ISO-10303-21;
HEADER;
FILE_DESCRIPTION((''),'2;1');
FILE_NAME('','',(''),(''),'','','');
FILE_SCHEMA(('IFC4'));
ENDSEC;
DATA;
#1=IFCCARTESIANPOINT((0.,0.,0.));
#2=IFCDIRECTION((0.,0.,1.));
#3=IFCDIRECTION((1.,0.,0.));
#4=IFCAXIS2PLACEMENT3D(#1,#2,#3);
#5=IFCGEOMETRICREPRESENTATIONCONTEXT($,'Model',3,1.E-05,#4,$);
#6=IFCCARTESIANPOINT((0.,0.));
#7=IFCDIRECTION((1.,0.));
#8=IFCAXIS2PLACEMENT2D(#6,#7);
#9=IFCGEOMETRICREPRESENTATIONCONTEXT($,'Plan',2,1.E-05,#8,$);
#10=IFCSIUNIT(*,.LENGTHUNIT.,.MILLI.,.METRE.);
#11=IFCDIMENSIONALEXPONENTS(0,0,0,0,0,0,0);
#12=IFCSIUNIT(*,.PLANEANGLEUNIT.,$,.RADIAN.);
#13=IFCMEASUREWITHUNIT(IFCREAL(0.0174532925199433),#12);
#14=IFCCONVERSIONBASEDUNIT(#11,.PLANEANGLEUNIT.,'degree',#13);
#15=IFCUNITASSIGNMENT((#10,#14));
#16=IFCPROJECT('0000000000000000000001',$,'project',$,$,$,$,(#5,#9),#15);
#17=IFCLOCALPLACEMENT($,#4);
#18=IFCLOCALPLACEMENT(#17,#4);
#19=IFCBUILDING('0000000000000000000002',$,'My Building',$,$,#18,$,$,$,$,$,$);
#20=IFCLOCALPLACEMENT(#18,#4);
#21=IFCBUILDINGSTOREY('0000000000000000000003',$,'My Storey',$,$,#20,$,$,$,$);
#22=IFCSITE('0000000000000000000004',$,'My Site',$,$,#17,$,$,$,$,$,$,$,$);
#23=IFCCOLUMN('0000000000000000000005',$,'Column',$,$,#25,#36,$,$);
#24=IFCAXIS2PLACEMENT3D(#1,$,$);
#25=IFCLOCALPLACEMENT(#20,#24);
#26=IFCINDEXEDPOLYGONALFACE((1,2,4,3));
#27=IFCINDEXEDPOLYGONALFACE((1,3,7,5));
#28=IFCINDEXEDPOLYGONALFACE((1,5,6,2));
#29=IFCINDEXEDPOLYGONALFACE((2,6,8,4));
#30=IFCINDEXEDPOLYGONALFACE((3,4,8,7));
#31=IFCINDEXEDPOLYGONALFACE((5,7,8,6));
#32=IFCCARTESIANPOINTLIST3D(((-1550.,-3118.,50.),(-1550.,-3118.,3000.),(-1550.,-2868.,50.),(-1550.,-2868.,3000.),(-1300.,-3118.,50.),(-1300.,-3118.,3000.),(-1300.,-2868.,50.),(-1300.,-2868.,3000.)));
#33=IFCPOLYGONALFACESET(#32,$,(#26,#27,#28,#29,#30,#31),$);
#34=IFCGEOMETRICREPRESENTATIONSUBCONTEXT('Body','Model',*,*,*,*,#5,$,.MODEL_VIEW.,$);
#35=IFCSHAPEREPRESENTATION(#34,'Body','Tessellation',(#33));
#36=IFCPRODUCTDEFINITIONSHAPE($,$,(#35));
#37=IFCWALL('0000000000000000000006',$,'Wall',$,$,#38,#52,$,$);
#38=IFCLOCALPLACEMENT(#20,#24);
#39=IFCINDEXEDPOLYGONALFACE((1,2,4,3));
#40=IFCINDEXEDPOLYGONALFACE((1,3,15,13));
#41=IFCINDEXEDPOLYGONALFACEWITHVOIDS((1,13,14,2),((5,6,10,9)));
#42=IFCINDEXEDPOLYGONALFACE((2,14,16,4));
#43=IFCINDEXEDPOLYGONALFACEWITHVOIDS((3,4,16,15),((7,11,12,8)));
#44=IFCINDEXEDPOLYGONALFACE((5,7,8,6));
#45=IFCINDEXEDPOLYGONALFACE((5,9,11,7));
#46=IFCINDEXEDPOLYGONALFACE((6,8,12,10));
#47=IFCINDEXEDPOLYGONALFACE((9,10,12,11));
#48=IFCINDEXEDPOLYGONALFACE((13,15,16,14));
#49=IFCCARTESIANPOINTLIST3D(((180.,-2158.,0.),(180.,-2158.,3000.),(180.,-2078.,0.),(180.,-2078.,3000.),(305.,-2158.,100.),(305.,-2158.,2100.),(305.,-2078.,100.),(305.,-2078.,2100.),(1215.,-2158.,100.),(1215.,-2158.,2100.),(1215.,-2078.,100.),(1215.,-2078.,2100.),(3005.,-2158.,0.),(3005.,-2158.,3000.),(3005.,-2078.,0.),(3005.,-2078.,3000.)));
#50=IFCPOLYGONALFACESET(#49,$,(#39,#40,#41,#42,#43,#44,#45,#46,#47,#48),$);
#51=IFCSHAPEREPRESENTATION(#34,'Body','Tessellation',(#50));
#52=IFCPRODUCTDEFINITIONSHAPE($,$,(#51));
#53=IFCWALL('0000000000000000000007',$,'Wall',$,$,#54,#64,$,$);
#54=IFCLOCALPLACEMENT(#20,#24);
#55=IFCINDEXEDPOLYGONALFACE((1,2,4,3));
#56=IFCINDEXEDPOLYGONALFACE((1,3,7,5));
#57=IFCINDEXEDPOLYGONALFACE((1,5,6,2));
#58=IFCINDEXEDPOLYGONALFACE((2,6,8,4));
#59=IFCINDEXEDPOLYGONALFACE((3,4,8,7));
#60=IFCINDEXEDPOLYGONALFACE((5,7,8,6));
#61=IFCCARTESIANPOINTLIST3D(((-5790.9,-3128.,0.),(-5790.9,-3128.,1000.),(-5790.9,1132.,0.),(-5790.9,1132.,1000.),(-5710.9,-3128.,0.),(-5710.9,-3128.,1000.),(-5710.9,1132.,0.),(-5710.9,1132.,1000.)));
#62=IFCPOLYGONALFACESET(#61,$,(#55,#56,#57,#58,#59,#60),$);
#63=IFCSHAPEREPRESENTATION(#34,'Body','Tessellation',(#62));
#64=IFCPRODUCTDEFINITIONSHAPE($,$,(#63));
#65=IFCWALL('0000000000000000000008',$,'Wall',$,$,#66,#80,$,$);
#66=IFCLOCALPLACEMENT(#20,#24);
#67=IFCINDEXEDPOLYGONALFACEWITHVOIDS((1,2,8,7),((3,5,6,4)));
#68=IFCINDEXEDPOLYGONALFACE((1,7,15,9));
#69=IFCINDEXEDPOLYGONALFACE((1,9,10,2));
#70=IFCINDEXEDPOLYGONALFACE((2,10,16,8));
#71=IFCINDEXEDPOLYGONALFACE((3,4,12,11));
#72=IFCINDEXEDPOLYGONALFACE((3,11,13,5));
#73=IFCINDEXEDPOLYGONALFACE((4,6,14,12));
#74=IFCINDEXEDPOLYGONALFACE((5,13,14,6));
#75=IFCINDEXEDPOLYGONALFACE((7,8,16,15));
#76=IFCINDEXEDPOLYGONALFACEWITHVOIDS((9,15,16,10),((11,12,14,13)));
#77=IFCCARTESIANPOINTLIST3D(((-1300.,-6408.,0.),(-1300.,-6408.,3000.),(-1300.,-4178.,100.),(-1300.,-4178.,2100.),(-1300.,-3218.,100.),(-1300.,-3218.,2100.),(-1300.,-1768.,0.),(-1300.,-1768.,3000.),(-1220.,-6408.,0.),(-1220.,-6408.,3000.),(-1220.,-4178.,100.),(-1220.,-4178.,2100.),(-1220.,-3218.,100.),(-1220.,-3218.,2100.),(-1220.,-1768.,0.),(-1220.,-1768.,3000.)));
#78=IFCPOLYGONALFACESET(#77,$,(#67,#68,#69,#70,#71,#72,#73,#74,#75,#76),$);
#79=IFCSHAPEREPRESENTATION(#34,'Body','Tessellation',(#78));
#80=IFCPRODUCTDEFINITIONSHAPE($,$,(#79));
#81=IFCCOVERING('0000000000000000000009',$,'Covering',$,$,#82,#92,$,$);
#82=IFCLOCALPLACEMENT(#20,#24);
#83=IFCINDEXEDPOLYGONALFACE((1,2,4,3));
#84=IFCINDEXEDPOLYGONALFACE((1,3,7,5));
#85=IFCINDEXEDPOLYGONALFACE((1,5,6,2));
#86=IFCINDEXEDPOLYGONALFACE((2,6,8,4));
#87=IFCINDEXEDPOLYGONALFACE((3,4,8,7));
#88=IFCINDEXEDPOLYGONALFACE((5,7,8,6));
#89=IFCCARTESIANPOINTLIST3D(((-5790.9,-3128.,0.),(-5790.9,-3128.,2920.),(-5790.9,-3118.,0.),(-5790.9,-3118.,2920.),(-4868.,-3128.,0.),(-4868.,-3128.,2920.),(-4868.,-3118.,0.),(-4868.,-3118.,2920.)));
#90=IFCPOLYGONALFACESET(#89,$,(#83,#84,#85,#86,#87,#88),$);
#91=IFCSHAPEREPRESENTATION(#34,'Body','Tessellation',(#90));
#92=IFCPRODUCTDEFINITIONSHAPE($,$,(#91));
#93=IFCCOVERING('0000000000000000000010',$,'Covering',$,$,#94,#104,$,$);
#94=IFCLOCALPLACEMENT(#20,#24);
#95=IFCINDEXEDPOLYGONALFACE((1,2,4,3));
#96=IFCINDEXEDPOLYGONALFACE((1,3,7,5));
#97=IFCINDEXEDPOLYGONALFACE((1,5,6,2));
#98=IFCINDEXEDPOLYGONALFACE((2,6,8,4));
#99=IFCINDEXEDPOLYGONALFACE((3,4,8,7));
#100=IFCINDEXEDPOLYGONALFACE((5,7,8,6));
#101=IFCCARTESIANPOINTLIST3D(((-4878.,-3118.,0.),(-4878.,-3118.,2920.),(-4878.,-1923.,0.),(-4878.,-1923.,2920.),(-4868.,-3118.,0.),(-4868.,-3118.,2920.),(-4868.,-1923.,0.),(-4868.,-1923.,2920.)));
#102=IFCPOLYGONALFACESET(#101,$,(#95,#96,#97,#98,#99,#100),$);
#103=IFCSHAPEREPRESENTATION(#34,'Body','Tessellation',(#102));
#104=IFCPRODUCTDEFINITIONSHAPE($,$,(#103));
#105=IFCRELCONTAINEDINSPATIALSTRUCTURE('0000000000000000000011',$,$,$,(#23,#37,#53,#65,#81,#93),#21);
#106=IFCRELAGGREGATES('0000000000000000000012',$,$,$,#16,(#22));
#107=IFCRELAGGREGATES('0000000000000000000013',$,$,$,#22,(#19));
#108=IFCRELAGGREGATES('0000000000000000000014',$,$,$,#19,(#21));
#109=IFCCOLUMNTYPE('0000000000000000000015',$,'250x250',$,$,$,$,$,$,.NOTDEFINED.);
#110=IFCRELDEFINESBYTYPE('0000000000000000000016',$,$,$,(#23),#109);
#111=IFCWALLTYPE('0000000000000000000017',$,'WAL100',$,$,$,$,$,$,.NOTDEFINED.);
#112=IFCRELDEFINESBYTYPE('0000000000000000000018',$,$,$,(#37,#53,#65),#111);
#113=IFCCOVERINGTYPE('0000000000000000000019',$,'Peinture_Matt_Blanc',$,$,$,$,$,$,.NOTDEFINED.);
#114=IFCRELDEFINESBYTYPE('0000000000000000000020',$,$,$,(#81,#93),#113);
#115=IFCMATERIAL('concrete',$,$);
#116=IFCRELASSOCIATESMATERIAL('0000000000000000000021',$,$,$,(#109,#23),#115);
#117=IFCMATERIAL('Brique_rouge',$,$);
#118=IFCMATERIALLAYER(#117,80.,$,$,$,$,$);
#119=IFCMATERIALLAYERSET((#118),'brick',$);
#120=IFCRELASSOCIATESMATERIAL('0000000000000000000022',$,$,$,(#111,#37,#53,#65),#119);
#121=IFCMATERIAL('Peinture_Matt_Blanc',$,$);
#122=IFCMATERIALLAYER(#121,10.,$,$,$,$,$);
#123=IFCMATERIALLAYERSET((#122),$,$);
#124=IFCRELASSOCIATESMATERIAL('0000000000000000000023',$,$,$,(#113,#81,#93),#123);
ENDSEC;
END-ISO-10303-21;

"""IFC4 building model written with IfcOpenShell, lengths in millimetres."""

from ifc_helpers import new_model, entity, si_unit, converted_unit, frame, origin_with_axes, origin_2d_with_axis, place, context, subcontext, project, spatial, line, indexed_curve, rectangle, outline, extrude, clip, halfspace, source, transform, mapped, material, layer, layer_set, layer_usage, material_profile, profile_set, profile_usage, type_object, element, save


model = new_model("IFC4")

# Units and contexts
model_context = context("Model", 3, precision=1e-05, world=origin_with_axes())
plan_context = context("Plan", 2, precision=1e-05, world=origin_2d_with_axis())
body_context = subcontext(model_context, "Body", "Model", "MODEL_VIEW")
ifc_project = project(units=[si_unit("LENGTHUNIT", "METRE", prefix="MILLI"), converted_unit("PLANEANGLEUNIT", "degree", entity("IfcReal", 0.0174532925199433), si_unit("PLANEANGLEUNIT", "RADIAN"), dimensions=[0, 0, 0, 0, 0, 0, 0])], contexts=[model_context, plan_context])

# Site, building, storey
site_placement = place(None, origin_with_axes())
site = spatial("IfcSite", under=ifc_project, at=site_placement, Name="My Site")
building_placement = place(site_placement, origin_with_axes())
building = spatial("IfcBuilding", under=site, at=building_placement, Name="My Building")
storey_placement = place(building_placement, origin_with_axes())
storey = spatial("IfcBuildingStorey", under=building, at=storey_placement, Name="My Storey")

# Column
ifc_material_1 = material(Name="concrete")
ifc_material_profile_1 = material_profile(ifc_material_1, rectangle(XDim=250.0, YDim=250.0))
ifc_profile_set_1 = profile_set([ifc_material_profile_1], Name="concrete")
ifc_profile_usage_1 = profile_usage(ifc_profile_set_1)
column_type_1 = type_object("IfcColumnType", Name="250x250", PredefinedType="NOTDEFINED", material=ifc_profile_set_1)
column_1_placement = place(storey_placement, frame((-1425.0, -2993.0, 50.0), z_axis=(0.0, 0.0, 1.0), x_axis=(1.0, 0.0, 0.0)))
element("IfcColumn", 1, at=column_1_placement, inside=storey, type_object=column_type_1, material=ifc_profile_usage_1, Name="Column", context=body_context, shape_type="SweptSolid", body=[
    extrude(rectangle(XDim=250.0, YDim=250.0), origin_with_axes(), (0.0, 0.0, 1.0), 2950.0),
])

# Wall, opening
ifc_material_2 = material(Name="Brique_rouge")
ifc_layer_1 = layer(ifc_material_2, 80.0)
ifc_layer_set_1 = layer_set([ifc_layer_1], Name="brick")
ifc_layer_usage_1 = layer_usage(ifc_layer_set_1, "AXIS2", "POSITIVE", 0.0)
wall_type = type_object("IfcWallType", Name="WAL100", PredefinedType="NOTDEFINED", material=ifc_layer_set_1)
wall_1_placement = place(storey_placement, frame((180.0, -2158.0, 0.0), z_axis=(0.0, 0.0, 1.0), x_axis=(1.0, -0.000001, 0.0)))
wall_1 = element("IfcWall", 2, at=wall_1_placement, inside=storey, type_object=wall_type, material=ifc_layer_usage_1, Name="Wall", context=body_context, shape_type="SweptSolid", body=[
    extrude(outline(indexed_curve([(0.0, 0.0), (0.0, 80.0), (2825.0, 80.0), (2825.0, 0.0), (0.0, 0.0)], self_intersect=False)), origin_with_axes(), (0.0, 0.0, 1.0), 3000.0),
])
shared_shape_1 = source(origin_with_axes(), body_context, "Body", "SweptSolid", [
    extrude(outline(indexed_curve([(0.0, 0.0), (910.0, 0.0), (910.0, 2000.0), (0.0, 2000.0)], segments=[line(3, 2), line(2, 1), line(1, 4), line(4, 3)], self_intersect=False)), frame((0.0, -100.0, 0.0), z_axis=(0.0, -1.0, 0.0), x_axis=(1.0, 0.0, 0.0)), (0.0, 0.0, -1.0), 280.0),
])
opening_1_placement = place(wall_1_placement, frame((125.0, 0.0, 100.0), z_axis=(0.0, 0.0, 1.0), x_axis=(1.0, 0.0, 0.0)))
element("IfcOpeningElement", 3, at=opening_1_placement, cuts=wall_1, PredefinedType="OPENING", context=body_context, shape_type="MappedRepresentation", body=[
    mapped(shared_shape_1, transform((0.0, 0.0, 0.0), x_axis=(1.0, 0.0, 0.0), y_axis=(0.0, 1.0, 0.0), z_axis=(0.0, 0.0, 1.0), scale=1.0)),
])

# Wall
ifc_layer_usage_2 = layer_usage(ifc_layer_set_1, "AXIS2", "POSITIVE", 0.0)
wall_2_placement = place(storey_placement, frame((-5710.9, -3128.0, 0.0), z_axis=(0.0, 0.0, 1.0), x_axis=(0.000002, 1.0, 0.0)))
element("IfcWall", 4, at=wall_2_placement, inside=storey, type_object=wall_type, material=ifc_layer_usage_2, Name="Wall", context=body_context, shape_type="SweptSolid", body=[
    extrude(outline(indexed_curve([(0.0, 0.0), (0.0, 80.0), (4260.0, 80.0), (4260.0, 0.0), (0.0, 0.0)], self_intersect=False)), origin_with_axes(), (0.0, 0.0, 1.0), 1000.0),
])

# Wall, opening
ifc_layer_usage_3 = layer_usage(ifc_layer_set_1, "AXIS2", "POSITIVE", 0.0)
wall_3_placement = place(storey_placement, frame((-1300.0, -1768.0, 0.0), z_axis=(0.0, 0.0, 1.0), x_axis=(-0.000001, -1.0, 0.0)))
wall_3 = element("IfcWall", 5, at=wall_3_placement, inside=storey, type_object=wall_type, material=ifc_layer_usage_3, Name="Wall", context=body_context, shape_type="SweptSolid", body=[
    extrude(outline(indexed_curve([(0.0, 0.0), (0.0, 80.0), (4640.0, 80.0), (4640.0, 0.0), (0.0, 0.0)], self_intersect=False)), origin_with_axes(), (0.0, 0.0, 1.0), 3000.0),
])
shared_shape_2 = source(origin_with_axes(), body_context, "Body", "SweptSolid", [
    extrude(outline(indexed_curve([(0.0, 0.0), (960.0, 0.0), (960.0, 2000.0), (0.0, 2000.0)], segments=[line(1, 2, 3, 4, 1)])), frame((0.0, -100.0, 0.0), z_axis=(0.0, -1.0, 0.0), x_axis=(1.0, 0.0, 0.0)), (0.0, 0.0, -1.0), 280.0),
])
opening_2_placement = place(wall_3_placement, frame((1450.0, 0.0, 100.0), z_axis=(0.0, 0.0, 1.0), x_axis=(1.0, 0.0, 0.0)))
element("IfcOpeningElement", 6, at=opening_2_placement, cuts=wall_3, PredefinedType="OPENING", context=body_context, shape_type="MappedRepresentation", body=[
    mapped(shared_shape_2, transform((0.0, 0.0, 0.0), x_axis=(1.0, 0.0, 0.0), y_axis=(0.0, 1.0, 0.0), z_axis=(0.0, 0.0, 1.0), scale=1.0)),
])

# Shared definitions
ifc_material_3 = material(Name="Peinture_Matt_Blanc")
ifc_layer_2 = layer(ifc_material_3, 10.0)
ifc_layer_set_2 = layer_set([ifc_layer_2])
covering_type_1 = type_object("IfcCoveringType", Name="Peinture_Matt_Blanc", PredefinedType="NOTDEFINED", material=ifc_layer_set_2)

# Coverings
ifc_layer_usage_4 = layer_usage(ifc_layer_set_2, "AXIS2", "POSITIVE", 0.0)
covering_1_placement = place(storey_placement, frame((-4868.0, -3118.0, 0.0), z_axis=(0.0, 0.0, 1.0), x_axis=(-1.0, 0.000001, 0.0)))
element("IfcCovering", 7, at=covering_1_placement, inside=storey, type_object=covering_type_1, material=ifc_layer_usage_4, Name="Covering", context=body_context, shape_type="Clipping", body=[
    clip(clip(extrude(outline(indexed_curve([(0.0, 0.0), (0.0, 10.0), (922.9, 10.0), (922.9, 0.0), (0.0, 0.0)], self_intersect=False)), origin_with_axes(), (0.0, 0.0, 1.0), 2920.0), halfspace(frame((0.0, 0.0, 2920.0), z_axis=(0.0, 0.0, 1.0), x_axis=(-1.0, 0.0, 0.0)), False)), halfspace(frame((0.0, 0.0, 2920.0), z_axis=(0.0, 0.0, 1.0), x_axis=(-1.0, 0.0, 0.0)), False)),
])
ifc_layer_usage_5 = layer_usage(ifc_layer_set_2, "AXIS2", "POSITIVE", 0.0)
covering_2_placement = place(storey_placement, frame((-4868.0, -3118.0, 0.0), z_axis=(0.0, 0.0, 1.0), x_axis=(0.000002, 1.0, 0.0)))
element("IfcCovering", 8, at=covering_2_placement, inside=storey, type_object=covering_type_1, material=ifc_layer_usage_5, Name="Covering", context=body_context, shape_type="Clipping", body=[
    clip(clip(extrude(outline(indexed_curve([(0.0, 0.0), (0.0, 10.0), (1195.0, 10.0), (1195.0, 0.0), (0.0, 0.0)], self_intersect=False)), origin_with_axes(), (0.0, 0.0, 1.0), 2920.0), halfspace(frame((0.0, 0.0, 2920.0), z_axis=(0.0, 0.0, 1.0), x_axis=(-1.0, 0.0, 0.0)), False)), halfspace(frame((0.0, 0.0, 2920.0), z_axis=(0.0, 0.0, 1.0), x_axis=(-1.0, 0.0, 0.0)), False)),
])

save(model, "model.ifc")
